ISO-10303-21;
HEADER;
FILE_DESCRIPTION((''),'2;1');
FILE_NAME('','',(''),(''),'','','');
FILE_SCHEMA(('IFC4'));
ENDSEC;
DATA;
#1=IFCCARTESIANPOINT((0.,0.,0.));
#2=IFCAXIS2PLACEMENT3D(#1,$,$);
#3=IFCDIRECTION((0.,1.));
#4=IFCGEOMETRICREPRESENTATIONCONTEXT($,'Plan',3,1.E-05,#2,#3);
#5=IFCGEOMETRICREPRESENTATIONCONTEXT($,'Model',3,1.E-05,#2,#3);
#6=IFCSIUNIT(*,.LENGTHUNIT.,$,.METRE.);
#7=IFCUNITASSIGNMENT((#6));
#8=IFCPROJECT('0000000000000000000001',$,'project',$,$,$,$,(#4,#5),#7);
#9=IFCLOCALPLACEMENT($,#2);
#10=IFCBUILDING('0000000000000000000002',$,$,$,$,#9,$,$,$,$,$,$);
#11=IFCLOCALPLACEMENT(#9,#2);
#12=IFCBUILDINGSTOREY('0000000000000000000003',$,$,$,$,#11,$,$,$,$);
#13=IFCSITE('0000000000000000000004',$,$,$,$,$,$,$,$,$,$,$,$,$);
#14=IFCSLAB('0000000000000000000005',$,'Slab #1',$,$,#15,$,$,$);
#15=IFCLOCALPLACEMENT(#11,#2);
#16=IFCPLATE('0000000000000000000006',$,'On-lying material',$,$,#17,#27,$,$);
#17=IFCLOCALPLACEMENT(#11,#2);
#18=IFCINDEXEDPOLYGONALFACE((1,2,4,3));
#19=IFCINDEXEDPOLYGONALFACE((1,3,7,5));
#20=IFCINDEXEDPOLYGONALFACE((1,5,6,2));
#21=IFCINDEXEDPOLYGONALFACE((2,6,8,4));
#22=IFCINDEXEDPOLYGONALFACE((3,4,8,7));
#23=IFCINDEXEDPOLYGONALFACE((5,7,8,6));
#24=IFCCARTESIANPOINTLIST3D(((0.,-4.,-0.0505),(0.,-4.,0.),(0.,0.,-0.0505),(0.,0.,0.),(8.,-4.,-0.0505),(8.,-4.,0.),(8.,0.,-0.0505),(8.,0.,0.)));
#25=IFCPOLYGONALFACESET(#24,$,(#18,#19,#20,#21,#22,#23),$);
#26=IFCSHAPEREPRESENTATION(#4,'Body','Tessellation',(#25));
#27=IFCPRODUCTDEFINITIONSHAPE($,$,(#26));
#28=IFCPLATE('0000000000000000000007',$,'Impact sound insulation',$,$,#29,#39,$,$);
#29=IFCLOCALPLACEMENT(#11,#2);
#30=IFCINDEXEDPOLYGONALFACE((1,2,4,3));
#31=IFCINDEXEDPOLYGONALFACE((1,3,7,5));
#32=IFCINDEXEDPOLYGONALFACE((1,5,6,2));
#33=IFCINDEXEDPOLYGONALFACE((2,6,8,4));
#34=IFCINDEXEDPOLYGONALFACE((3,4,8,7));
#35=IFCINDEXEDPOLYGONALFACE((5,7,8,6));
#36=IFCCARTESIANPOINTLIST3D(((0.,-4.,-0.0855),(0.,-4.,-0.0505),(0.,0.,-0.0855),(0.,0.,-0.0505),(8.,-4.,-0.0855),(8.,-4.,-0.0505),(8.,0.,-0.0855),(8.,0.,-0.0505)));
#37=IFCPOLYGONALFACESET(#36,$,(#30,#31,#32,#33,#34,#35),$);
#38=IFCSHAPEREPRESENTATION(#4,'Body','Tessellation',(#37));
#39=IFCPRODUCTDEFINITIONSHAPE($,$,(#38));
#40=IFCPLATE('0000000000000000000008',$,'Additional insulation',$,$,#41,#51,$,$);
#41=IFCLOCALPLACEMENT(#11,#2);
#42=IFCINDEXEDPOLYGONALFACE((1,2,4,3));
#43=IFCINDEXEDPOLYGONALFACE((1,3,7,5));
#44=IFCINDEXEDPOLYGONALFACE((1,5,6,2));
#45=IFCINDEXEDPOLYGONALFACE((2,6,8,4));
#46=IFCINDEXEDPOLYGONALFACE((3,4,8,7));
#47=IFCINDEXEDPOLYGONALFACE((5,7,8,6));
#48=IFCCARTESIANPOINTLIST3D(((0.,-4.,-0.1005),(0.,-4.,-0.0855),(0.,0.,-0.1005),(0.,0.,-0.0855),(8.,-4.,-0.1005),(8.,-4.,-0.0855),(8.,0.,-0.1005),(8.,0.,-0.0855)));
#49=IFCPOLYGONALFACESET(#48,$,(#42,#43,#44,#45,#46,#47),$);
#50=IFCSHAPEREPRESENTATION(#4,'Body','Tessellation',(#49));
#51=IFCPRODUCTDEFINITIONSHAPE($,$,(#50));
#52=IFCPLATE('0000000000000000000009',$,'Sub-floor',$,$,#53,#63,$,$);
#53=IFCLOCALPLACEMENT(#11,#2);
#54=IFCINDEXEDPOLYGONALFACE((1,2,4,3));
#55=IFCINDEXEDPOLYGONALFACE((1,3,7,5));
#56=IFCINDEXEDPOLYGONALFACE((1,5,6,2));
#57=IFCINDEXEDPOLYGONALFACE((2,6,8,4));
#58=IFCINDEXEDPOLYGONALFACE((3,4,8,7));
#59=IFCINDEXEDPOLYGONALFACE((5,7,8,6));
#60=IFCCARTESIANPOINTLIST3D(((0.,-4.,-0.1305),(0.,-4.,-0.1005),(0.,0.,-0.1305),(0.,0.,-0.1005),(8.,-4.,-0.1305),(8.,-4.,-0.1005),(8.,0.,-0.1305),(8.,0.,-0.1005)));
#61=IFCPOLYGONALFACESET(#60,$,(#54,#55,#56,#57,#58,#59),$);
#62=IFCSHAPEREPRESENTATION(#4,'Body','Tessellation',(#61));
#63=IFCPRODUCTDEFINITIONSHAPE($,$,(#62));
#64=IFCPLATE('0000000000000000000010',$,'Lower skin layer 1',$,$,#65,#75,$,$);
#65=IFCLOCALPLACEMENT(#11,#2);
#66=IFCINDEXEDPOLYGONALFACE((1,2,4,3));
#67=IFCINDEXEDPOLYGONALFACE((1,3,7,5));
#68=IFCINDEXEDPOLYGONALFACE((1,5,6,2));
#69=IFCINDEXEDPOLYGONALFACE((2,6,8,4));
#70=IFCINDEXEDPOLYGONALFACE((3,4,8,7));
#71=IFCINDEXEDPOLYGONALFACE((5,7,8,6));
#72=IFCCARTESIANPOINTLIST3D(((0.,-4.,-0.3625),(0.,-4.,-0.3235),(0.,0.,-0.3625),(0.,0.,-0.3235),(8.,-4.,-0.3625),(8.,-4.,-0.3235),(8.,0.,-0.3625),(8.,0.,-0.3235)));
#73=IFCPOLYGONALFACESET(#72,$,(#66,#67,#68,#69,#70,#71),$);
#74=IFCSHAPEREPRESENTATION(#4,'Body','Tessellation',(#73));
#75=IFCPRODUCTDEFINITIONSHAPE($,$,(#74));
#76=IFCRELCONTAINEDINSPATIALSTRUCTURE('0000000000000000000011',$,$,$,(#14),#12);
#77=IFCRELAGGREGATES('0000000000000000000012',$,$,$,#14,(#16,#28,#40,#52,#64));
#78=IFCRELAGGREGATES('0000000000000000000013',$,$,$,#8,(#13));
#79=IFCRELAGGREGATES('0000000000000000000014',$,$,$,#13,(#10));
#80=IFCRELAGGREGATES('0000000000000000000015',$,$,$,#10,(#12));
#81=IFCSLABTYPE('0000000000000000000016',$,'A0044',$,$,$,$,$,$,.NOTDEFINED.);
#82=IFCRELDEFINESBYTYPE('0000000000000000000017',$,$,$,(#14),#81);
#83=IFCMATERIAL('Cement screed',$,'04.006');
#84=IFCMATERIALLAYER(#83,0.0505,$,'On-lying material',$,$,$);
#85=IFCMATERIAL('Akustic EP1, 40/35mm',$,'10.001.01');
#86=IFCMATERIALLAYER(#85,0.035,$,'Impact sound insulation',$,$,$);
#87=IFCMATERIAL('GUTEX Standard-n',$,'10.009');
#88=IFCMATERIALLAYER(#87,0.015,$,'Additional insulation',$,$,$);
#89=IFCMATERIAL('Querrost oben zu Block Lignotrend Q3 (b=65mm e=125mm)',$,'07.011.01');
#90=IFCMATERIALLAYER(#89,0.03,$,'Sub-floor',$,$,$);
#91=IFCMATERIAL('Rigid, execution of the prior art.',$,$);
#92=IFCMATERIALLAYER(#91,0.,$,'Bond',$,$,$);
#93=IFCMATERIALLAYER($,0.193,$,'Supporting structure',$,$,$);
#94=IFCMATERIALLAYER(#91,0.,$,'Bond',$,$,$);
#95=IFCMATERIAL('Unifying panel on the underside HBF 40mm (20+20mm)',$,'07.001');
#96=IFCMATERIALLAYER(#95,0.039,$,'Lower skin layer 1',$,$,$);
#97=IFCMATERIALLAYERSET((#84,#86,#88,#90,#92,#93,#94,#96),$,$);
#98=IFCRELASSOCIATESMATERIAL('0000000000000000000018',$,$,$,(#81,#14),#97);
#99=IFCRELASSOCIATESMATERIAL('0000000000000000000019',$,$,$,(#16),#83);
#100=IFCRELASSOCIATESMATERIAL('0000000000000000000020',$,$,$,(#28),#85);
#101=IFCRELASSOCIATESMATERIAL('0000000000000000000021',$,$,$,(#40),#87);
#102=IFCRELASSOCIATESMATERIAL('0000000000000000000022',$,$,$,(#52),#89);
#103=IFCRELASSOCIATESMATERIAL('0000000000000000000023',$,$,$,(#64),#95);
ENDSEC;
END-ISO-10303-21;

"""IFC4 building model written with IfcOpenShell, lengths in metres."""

from ifc_helpers import new_model, si_unit, direction, frame, frame_2d, origin, origin_with_axes, place, context, project, spatial, rectangle, extrude, material, layer, layer_set, type_object, element, aggregate, save


model = new_model("IFC4")

# Units and contexts
plan_context = context("Plan", 3, precision=1e-05, world=origin(), true_north=direction((0.0, 1.0)))
model_context = context("Model", 3, precision=1e-05, world=origin(), true_north=direction((0.0, 1.0)))
ifc_project = project(units=[si_unit("LENGTHUNIT", "METRE")], contexts=[plan_context, model_context])

# Site, building, storey
site = spatial("IfcSite", under=ifc_project)
building_placement = place(None, origin())
building = spatial("IfcBuilding", under=site, at=building_placement)
storey_placement = place(building_placement, origin())
storey = spatial("IfcBuildingStorey", under=building, at=storey_placement)

# Slab, plates
ifc_material_1 = material(Name="Cement screed", Category="04.006")
ifc_layer_1 = layer(ifc_material_1, 0.0505, Name="On-lying material")
ifc_material_2 = material(Name="Akustic EP1, 40/35mm", Category="10.001.01")
ifc_layer_2 = layer(ifc_material_2, 0.035, Name="Impact sound insulation")
ifc_material_3 = material(Name="GUTEX Standard-n", Category="10.009")
ifc_layer_3 = layer(ifc_material_3, 0.015, Name="Additional insulation")
ifc_material_4 = material(Name="Querrost oben zu Block Lignotrend Q3 (b=65mm e=125mm)", Category="07.011.01")
ifc_layer_4 = layer(ifc_material_4, 0.03, Name="Sub-floor")
ifc_material_5 = material(Name="Rigid, execution of the prior art.")
ifc_layer_5 = layer(ifc_material_5, 0.0, Name="Bond")
ifc_layer_6 = layer(None, 0.193, Name="Supporting structure")
ifc_layer_7 = layer(ifc_material_5, 0.0, Name="Bond")
ifc_material_6 = material(Name="Unifying panel on the underside HBF 40mm (20+20mm)", Category="07.001")
ifc_layer_8 = layer(ifc_material_6, 0.039, Name="Lower skin layer 1")
ifc_layer_set = layer_set([ifc_layer_1, ifc_layer_2, ifc_layer_3, ifc_layer_4, ifc_layer_5, ifc_layer_6, ifc_layer_7, ifc_layer_8])
slab_type = type_object("IfcSlabType", Name="A0044", PredefinedType="NOTDEFINED", material=ifc_layer_set)
slab_placement = place(None, frame((0.0, 0.0, 0.0), z_axis=(0.0, 0.0, -1.0), x_axis=(1.0, 0.0, 0.0)))
slab = element("IfcSlab", 1, at=slab_placement, inside=storey, type_object=slab_type, material=ifc_layer_set, Name="Slab #1")
plate_1_placement = place(slab_placement, origin())
plate_1 = element("IfcPlate", 2, at=plate_1_placement, material=ifc_material_1, Name="On-lying material", context=plan_context, shape_type="SweptSolid", body=[
    extrude(rectangle(XDim=8.0, YDim=4.0, at=frame_2d((4.0, 2.0), x_axis=(1.0, 0.0))), origin_with_axes(), (0.0, 0.0, 1.0), 0.0505),
])
plate_2_placement = place(slab_placement, origin())
plate_2 = element("IfcPlate", 3, at=plate_2_placement, material=ifc_material_2, Name="Impact sound insulation", context=plan_context, shape_type="SweptSolid", body=[
    extrude(rectangle(XDim=8.0, YDim=4.0, at=frame_2d((4.0, 2.0), x_axis=(1.0, 0.0))), frame((0.0, 0.0, 0.0505), z_axis=(0.0, 0.0, 1.0), x_axis=(1.0, 0.0, 0.0)), (0.0, 0.0, 1.0), 0.035),
])
plate_3_placement = place(slab_placement, origin())
plate_3 = element("IfcPlate", 4, at=plate_3_placement, material=ifc_material_3, Name="Additional insulation", context=plan_context, shape_type="SweptSolid", body=[
    extrude(rectangle(XDim=8.0, YDim=4.0, at=frame_2d((4.0, 2.0), x_axis=(1.0, 0.0))), frame((0.0, 0.0, 0.0855), z_axis=(0.0, 0.0, 1.0), x_axis=(1.0, 0.0, 0.0)), (0.0, 0.0, 1.0), 0.015),
])
plate_4_placement = place(slab_placement, origin())
plate_4 = element("IfcPlate", 5, at=plate_4_placement, material=ifc_material_4, Name="Sub-floor", context=plan_context, shape_type="SweptSolid", body=[
    extrude(rectangle(XDim=8.0, YDim=4.0, at=frame_2d((4.0, 2.0), x_axis=(1.0, 0.0))), frame((0.0, 0.0, 0.1005), z_axis=(0.0, 0.0, 1.0), x_axis=(1.0, 0.0, 0.0)), (0.0, 0.0, 1.0), 0.03),
])
plate_5_placement = place(slab_placement, origin())
plate_5 = element("IfcPlate", 6, at=plate_5_placement, material=ifc_material_6, Name="Lower skin layer 1", context=plan_context, shape_type="SweptSolid", body=[
    extrude(rectangle(XDim=8.0, YDim=4.0, at=frame_2d((4.0, 2.0), x_axis=(1.0, 0.0))), frame((0.0, 0.0, 0.3235), z_axis=(0.0, 0.0, 1.0), x_axis=(1.0, 0.0, 0.0)), (0.0, 0.0, 1.0), 0.039),
])
aggregate(slab, [plate_1, plate_2, plate_3, plate_4, plate_5])

save(model, "model.ifc")
